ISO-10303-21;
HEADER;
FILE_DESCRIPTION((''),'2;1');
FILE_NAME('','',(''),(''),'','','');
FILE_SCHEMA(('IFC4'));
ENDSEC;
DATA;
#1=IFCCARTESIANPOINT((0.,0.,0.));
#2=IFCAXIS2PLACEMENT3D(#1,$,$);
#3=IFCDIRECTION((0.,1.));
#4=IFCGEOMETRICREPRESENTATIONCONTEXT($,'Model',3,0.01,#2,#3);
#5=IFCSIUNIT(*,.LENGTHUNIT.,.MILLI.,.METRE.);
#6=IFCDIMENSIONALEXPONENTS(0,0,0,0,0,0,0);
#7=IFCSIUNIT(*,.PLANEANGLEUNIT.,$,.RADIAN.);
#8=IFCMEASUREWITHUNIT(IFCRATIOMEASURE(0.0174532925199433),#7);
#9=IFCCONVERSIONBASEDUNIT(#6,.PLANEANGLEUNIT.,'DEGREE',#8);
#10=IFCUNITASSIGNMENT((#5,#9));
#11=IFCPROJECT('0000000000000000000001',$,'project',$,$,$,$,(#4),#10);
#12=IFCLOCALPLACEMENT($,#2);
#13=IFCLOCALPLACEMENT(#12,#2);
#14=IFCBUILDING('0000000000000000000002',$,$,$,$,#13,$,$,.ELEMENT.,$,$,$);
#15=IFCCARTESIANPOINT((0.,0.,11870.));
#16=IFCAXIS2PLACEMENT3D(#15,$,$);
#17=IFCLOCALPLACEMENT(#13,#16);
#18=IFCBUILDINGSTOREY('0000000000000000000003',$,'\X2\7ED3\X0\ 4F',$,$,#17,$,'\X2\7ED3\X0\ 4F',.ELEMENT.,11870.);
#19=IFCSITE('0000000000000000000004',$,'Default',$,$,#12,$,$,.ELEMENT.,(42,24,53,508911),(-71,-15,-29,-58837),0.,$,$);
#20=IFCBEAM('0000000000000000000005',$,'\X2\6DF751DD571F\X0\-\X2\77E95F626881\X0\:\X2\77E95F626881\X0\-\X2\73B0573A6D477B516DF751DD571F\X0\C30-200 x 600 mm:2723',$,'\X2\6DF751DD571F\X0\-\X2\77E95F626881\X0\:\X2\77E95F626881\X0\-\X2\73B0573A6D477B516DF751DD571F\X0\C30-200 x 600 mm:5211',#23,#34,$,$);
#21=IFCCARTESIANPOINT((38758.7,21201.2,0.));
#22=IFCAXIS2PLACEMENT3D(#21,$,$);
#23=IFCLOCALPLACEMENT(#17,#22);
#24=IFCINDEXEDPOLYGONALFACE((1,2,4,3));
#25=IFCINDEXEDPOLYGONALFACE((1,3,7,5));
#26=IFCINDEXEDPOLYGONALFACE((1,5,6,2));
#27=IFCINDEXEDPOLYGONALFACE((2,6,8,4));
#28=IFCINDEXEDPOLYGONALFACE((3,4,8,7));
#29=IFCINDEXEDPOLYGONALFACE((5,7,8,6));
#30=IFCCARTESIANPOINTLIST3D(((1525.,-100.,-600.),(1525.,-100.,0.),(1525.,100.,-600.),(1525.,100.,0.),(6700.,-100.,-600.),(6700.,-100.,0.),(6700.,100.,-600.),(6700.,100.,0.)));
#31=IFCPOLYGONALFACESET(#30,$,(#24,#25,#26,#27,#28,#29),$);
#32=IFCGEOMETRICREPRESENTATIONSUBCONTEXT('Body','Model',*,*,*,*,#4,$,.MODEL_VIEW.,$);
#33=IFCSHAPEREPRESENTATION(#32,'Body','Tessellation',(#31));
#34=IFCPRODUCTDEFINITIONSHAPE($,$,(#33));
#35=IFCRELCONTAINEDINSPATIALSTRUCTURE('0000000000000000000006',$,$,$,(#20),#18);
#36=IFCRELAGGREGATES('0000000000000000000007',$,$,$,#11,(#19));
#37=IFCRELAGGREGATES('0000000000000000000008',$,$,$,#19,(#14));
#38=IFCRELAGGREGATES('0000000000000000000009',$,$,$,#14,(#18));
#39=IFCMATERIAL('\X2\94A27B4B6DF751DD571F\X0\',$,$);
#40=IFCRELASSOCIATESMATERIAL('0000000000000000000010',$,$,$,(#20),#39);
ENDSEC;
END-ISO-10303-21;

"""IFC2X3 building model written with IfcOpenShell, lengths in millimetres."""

from ifc_helpers import new_model, entity, si_unit, converted_unit, direction, frame, frame_2d, origin, place, context, subcontext, project, spatial, rectangle, extrude, material, element, save


model = new_model("IFC2X3")

# Units and contexts
model_context = context("Model", 3, precision=0.01, world=origin(), true_north=direction((0.0, 1.0)))
body_context = subcontext(model_context, "Body", "Model", "MODEL_VIEW")
ifc_project = project(units=[si_unit("LENGTHUNIT", "METRE", prefix="MILLI"), converted_unit("PLANEANGLEUNIT", "DEGREE", entity("IfcRatioMeasure", 0.0174532925199433), si_unit("PLANEANGLEUNIT", "RADIAN"), dimensions=[0, 0, 0, 0, 0, 0, 0])], contexts=[model_context])

# Site, building, storey
site_placement = place(None, origin())
site = spatial("IfcSite", under=ifc_project, at=site_placement, Name="Default", CompositionType="ELEMENT", RefLatitude=(42, 24, 53, 508911), RefLongitude=(-71, -15, -29, -58837), RefElevation=0.0)
building_placement = place(site_placement, origin())
building = spatial("IfcBuilding", under=site, at=building_placement, CompositionType="ELEMENT")
storey_placement = place(building_placement, frame((0.0, 0.0, 11870.0)))
storey = spatial("IfcBuildingStorey", under=building, at=storey_placement, Name="结 4F", LongName="结 4F", CompositionType="ELEMENT", Elevation=11870.0)

# Beam
ifc_material = material(Name="钢筋混凝土")
beam_1_placement = place(storey_placement, frame((38758.7, 21201.2, 0.0)))
element("IfcBeam", 1, at=beam_1_placement, inside=storey, material=ifc_material, Name="混凝土-矩形梁:矩形梁-现场浇筑混凝土C30-200 x 600 mm:2723", ObjectType="混凝土-矩形梁:矩形梁-现场浇筑混凝土C30-200 x 600 mm:5211", context=body_context, shape_type="SweptSolid", body=[
    extrude(rectangle(XDim=600.0, YDim=200.0, at=frame_2d((0.0, 0.0), x_axis=(1.0, 0.0))), frame((1525.0, 0.0, -300.0), z_axis=(1.0, 0.0, 0.0), x_axis=(0.0, 0.0, -1.0)), (0.0, 0.0, 1.0), 5175.0),
])

save(model, "model.ifc")
